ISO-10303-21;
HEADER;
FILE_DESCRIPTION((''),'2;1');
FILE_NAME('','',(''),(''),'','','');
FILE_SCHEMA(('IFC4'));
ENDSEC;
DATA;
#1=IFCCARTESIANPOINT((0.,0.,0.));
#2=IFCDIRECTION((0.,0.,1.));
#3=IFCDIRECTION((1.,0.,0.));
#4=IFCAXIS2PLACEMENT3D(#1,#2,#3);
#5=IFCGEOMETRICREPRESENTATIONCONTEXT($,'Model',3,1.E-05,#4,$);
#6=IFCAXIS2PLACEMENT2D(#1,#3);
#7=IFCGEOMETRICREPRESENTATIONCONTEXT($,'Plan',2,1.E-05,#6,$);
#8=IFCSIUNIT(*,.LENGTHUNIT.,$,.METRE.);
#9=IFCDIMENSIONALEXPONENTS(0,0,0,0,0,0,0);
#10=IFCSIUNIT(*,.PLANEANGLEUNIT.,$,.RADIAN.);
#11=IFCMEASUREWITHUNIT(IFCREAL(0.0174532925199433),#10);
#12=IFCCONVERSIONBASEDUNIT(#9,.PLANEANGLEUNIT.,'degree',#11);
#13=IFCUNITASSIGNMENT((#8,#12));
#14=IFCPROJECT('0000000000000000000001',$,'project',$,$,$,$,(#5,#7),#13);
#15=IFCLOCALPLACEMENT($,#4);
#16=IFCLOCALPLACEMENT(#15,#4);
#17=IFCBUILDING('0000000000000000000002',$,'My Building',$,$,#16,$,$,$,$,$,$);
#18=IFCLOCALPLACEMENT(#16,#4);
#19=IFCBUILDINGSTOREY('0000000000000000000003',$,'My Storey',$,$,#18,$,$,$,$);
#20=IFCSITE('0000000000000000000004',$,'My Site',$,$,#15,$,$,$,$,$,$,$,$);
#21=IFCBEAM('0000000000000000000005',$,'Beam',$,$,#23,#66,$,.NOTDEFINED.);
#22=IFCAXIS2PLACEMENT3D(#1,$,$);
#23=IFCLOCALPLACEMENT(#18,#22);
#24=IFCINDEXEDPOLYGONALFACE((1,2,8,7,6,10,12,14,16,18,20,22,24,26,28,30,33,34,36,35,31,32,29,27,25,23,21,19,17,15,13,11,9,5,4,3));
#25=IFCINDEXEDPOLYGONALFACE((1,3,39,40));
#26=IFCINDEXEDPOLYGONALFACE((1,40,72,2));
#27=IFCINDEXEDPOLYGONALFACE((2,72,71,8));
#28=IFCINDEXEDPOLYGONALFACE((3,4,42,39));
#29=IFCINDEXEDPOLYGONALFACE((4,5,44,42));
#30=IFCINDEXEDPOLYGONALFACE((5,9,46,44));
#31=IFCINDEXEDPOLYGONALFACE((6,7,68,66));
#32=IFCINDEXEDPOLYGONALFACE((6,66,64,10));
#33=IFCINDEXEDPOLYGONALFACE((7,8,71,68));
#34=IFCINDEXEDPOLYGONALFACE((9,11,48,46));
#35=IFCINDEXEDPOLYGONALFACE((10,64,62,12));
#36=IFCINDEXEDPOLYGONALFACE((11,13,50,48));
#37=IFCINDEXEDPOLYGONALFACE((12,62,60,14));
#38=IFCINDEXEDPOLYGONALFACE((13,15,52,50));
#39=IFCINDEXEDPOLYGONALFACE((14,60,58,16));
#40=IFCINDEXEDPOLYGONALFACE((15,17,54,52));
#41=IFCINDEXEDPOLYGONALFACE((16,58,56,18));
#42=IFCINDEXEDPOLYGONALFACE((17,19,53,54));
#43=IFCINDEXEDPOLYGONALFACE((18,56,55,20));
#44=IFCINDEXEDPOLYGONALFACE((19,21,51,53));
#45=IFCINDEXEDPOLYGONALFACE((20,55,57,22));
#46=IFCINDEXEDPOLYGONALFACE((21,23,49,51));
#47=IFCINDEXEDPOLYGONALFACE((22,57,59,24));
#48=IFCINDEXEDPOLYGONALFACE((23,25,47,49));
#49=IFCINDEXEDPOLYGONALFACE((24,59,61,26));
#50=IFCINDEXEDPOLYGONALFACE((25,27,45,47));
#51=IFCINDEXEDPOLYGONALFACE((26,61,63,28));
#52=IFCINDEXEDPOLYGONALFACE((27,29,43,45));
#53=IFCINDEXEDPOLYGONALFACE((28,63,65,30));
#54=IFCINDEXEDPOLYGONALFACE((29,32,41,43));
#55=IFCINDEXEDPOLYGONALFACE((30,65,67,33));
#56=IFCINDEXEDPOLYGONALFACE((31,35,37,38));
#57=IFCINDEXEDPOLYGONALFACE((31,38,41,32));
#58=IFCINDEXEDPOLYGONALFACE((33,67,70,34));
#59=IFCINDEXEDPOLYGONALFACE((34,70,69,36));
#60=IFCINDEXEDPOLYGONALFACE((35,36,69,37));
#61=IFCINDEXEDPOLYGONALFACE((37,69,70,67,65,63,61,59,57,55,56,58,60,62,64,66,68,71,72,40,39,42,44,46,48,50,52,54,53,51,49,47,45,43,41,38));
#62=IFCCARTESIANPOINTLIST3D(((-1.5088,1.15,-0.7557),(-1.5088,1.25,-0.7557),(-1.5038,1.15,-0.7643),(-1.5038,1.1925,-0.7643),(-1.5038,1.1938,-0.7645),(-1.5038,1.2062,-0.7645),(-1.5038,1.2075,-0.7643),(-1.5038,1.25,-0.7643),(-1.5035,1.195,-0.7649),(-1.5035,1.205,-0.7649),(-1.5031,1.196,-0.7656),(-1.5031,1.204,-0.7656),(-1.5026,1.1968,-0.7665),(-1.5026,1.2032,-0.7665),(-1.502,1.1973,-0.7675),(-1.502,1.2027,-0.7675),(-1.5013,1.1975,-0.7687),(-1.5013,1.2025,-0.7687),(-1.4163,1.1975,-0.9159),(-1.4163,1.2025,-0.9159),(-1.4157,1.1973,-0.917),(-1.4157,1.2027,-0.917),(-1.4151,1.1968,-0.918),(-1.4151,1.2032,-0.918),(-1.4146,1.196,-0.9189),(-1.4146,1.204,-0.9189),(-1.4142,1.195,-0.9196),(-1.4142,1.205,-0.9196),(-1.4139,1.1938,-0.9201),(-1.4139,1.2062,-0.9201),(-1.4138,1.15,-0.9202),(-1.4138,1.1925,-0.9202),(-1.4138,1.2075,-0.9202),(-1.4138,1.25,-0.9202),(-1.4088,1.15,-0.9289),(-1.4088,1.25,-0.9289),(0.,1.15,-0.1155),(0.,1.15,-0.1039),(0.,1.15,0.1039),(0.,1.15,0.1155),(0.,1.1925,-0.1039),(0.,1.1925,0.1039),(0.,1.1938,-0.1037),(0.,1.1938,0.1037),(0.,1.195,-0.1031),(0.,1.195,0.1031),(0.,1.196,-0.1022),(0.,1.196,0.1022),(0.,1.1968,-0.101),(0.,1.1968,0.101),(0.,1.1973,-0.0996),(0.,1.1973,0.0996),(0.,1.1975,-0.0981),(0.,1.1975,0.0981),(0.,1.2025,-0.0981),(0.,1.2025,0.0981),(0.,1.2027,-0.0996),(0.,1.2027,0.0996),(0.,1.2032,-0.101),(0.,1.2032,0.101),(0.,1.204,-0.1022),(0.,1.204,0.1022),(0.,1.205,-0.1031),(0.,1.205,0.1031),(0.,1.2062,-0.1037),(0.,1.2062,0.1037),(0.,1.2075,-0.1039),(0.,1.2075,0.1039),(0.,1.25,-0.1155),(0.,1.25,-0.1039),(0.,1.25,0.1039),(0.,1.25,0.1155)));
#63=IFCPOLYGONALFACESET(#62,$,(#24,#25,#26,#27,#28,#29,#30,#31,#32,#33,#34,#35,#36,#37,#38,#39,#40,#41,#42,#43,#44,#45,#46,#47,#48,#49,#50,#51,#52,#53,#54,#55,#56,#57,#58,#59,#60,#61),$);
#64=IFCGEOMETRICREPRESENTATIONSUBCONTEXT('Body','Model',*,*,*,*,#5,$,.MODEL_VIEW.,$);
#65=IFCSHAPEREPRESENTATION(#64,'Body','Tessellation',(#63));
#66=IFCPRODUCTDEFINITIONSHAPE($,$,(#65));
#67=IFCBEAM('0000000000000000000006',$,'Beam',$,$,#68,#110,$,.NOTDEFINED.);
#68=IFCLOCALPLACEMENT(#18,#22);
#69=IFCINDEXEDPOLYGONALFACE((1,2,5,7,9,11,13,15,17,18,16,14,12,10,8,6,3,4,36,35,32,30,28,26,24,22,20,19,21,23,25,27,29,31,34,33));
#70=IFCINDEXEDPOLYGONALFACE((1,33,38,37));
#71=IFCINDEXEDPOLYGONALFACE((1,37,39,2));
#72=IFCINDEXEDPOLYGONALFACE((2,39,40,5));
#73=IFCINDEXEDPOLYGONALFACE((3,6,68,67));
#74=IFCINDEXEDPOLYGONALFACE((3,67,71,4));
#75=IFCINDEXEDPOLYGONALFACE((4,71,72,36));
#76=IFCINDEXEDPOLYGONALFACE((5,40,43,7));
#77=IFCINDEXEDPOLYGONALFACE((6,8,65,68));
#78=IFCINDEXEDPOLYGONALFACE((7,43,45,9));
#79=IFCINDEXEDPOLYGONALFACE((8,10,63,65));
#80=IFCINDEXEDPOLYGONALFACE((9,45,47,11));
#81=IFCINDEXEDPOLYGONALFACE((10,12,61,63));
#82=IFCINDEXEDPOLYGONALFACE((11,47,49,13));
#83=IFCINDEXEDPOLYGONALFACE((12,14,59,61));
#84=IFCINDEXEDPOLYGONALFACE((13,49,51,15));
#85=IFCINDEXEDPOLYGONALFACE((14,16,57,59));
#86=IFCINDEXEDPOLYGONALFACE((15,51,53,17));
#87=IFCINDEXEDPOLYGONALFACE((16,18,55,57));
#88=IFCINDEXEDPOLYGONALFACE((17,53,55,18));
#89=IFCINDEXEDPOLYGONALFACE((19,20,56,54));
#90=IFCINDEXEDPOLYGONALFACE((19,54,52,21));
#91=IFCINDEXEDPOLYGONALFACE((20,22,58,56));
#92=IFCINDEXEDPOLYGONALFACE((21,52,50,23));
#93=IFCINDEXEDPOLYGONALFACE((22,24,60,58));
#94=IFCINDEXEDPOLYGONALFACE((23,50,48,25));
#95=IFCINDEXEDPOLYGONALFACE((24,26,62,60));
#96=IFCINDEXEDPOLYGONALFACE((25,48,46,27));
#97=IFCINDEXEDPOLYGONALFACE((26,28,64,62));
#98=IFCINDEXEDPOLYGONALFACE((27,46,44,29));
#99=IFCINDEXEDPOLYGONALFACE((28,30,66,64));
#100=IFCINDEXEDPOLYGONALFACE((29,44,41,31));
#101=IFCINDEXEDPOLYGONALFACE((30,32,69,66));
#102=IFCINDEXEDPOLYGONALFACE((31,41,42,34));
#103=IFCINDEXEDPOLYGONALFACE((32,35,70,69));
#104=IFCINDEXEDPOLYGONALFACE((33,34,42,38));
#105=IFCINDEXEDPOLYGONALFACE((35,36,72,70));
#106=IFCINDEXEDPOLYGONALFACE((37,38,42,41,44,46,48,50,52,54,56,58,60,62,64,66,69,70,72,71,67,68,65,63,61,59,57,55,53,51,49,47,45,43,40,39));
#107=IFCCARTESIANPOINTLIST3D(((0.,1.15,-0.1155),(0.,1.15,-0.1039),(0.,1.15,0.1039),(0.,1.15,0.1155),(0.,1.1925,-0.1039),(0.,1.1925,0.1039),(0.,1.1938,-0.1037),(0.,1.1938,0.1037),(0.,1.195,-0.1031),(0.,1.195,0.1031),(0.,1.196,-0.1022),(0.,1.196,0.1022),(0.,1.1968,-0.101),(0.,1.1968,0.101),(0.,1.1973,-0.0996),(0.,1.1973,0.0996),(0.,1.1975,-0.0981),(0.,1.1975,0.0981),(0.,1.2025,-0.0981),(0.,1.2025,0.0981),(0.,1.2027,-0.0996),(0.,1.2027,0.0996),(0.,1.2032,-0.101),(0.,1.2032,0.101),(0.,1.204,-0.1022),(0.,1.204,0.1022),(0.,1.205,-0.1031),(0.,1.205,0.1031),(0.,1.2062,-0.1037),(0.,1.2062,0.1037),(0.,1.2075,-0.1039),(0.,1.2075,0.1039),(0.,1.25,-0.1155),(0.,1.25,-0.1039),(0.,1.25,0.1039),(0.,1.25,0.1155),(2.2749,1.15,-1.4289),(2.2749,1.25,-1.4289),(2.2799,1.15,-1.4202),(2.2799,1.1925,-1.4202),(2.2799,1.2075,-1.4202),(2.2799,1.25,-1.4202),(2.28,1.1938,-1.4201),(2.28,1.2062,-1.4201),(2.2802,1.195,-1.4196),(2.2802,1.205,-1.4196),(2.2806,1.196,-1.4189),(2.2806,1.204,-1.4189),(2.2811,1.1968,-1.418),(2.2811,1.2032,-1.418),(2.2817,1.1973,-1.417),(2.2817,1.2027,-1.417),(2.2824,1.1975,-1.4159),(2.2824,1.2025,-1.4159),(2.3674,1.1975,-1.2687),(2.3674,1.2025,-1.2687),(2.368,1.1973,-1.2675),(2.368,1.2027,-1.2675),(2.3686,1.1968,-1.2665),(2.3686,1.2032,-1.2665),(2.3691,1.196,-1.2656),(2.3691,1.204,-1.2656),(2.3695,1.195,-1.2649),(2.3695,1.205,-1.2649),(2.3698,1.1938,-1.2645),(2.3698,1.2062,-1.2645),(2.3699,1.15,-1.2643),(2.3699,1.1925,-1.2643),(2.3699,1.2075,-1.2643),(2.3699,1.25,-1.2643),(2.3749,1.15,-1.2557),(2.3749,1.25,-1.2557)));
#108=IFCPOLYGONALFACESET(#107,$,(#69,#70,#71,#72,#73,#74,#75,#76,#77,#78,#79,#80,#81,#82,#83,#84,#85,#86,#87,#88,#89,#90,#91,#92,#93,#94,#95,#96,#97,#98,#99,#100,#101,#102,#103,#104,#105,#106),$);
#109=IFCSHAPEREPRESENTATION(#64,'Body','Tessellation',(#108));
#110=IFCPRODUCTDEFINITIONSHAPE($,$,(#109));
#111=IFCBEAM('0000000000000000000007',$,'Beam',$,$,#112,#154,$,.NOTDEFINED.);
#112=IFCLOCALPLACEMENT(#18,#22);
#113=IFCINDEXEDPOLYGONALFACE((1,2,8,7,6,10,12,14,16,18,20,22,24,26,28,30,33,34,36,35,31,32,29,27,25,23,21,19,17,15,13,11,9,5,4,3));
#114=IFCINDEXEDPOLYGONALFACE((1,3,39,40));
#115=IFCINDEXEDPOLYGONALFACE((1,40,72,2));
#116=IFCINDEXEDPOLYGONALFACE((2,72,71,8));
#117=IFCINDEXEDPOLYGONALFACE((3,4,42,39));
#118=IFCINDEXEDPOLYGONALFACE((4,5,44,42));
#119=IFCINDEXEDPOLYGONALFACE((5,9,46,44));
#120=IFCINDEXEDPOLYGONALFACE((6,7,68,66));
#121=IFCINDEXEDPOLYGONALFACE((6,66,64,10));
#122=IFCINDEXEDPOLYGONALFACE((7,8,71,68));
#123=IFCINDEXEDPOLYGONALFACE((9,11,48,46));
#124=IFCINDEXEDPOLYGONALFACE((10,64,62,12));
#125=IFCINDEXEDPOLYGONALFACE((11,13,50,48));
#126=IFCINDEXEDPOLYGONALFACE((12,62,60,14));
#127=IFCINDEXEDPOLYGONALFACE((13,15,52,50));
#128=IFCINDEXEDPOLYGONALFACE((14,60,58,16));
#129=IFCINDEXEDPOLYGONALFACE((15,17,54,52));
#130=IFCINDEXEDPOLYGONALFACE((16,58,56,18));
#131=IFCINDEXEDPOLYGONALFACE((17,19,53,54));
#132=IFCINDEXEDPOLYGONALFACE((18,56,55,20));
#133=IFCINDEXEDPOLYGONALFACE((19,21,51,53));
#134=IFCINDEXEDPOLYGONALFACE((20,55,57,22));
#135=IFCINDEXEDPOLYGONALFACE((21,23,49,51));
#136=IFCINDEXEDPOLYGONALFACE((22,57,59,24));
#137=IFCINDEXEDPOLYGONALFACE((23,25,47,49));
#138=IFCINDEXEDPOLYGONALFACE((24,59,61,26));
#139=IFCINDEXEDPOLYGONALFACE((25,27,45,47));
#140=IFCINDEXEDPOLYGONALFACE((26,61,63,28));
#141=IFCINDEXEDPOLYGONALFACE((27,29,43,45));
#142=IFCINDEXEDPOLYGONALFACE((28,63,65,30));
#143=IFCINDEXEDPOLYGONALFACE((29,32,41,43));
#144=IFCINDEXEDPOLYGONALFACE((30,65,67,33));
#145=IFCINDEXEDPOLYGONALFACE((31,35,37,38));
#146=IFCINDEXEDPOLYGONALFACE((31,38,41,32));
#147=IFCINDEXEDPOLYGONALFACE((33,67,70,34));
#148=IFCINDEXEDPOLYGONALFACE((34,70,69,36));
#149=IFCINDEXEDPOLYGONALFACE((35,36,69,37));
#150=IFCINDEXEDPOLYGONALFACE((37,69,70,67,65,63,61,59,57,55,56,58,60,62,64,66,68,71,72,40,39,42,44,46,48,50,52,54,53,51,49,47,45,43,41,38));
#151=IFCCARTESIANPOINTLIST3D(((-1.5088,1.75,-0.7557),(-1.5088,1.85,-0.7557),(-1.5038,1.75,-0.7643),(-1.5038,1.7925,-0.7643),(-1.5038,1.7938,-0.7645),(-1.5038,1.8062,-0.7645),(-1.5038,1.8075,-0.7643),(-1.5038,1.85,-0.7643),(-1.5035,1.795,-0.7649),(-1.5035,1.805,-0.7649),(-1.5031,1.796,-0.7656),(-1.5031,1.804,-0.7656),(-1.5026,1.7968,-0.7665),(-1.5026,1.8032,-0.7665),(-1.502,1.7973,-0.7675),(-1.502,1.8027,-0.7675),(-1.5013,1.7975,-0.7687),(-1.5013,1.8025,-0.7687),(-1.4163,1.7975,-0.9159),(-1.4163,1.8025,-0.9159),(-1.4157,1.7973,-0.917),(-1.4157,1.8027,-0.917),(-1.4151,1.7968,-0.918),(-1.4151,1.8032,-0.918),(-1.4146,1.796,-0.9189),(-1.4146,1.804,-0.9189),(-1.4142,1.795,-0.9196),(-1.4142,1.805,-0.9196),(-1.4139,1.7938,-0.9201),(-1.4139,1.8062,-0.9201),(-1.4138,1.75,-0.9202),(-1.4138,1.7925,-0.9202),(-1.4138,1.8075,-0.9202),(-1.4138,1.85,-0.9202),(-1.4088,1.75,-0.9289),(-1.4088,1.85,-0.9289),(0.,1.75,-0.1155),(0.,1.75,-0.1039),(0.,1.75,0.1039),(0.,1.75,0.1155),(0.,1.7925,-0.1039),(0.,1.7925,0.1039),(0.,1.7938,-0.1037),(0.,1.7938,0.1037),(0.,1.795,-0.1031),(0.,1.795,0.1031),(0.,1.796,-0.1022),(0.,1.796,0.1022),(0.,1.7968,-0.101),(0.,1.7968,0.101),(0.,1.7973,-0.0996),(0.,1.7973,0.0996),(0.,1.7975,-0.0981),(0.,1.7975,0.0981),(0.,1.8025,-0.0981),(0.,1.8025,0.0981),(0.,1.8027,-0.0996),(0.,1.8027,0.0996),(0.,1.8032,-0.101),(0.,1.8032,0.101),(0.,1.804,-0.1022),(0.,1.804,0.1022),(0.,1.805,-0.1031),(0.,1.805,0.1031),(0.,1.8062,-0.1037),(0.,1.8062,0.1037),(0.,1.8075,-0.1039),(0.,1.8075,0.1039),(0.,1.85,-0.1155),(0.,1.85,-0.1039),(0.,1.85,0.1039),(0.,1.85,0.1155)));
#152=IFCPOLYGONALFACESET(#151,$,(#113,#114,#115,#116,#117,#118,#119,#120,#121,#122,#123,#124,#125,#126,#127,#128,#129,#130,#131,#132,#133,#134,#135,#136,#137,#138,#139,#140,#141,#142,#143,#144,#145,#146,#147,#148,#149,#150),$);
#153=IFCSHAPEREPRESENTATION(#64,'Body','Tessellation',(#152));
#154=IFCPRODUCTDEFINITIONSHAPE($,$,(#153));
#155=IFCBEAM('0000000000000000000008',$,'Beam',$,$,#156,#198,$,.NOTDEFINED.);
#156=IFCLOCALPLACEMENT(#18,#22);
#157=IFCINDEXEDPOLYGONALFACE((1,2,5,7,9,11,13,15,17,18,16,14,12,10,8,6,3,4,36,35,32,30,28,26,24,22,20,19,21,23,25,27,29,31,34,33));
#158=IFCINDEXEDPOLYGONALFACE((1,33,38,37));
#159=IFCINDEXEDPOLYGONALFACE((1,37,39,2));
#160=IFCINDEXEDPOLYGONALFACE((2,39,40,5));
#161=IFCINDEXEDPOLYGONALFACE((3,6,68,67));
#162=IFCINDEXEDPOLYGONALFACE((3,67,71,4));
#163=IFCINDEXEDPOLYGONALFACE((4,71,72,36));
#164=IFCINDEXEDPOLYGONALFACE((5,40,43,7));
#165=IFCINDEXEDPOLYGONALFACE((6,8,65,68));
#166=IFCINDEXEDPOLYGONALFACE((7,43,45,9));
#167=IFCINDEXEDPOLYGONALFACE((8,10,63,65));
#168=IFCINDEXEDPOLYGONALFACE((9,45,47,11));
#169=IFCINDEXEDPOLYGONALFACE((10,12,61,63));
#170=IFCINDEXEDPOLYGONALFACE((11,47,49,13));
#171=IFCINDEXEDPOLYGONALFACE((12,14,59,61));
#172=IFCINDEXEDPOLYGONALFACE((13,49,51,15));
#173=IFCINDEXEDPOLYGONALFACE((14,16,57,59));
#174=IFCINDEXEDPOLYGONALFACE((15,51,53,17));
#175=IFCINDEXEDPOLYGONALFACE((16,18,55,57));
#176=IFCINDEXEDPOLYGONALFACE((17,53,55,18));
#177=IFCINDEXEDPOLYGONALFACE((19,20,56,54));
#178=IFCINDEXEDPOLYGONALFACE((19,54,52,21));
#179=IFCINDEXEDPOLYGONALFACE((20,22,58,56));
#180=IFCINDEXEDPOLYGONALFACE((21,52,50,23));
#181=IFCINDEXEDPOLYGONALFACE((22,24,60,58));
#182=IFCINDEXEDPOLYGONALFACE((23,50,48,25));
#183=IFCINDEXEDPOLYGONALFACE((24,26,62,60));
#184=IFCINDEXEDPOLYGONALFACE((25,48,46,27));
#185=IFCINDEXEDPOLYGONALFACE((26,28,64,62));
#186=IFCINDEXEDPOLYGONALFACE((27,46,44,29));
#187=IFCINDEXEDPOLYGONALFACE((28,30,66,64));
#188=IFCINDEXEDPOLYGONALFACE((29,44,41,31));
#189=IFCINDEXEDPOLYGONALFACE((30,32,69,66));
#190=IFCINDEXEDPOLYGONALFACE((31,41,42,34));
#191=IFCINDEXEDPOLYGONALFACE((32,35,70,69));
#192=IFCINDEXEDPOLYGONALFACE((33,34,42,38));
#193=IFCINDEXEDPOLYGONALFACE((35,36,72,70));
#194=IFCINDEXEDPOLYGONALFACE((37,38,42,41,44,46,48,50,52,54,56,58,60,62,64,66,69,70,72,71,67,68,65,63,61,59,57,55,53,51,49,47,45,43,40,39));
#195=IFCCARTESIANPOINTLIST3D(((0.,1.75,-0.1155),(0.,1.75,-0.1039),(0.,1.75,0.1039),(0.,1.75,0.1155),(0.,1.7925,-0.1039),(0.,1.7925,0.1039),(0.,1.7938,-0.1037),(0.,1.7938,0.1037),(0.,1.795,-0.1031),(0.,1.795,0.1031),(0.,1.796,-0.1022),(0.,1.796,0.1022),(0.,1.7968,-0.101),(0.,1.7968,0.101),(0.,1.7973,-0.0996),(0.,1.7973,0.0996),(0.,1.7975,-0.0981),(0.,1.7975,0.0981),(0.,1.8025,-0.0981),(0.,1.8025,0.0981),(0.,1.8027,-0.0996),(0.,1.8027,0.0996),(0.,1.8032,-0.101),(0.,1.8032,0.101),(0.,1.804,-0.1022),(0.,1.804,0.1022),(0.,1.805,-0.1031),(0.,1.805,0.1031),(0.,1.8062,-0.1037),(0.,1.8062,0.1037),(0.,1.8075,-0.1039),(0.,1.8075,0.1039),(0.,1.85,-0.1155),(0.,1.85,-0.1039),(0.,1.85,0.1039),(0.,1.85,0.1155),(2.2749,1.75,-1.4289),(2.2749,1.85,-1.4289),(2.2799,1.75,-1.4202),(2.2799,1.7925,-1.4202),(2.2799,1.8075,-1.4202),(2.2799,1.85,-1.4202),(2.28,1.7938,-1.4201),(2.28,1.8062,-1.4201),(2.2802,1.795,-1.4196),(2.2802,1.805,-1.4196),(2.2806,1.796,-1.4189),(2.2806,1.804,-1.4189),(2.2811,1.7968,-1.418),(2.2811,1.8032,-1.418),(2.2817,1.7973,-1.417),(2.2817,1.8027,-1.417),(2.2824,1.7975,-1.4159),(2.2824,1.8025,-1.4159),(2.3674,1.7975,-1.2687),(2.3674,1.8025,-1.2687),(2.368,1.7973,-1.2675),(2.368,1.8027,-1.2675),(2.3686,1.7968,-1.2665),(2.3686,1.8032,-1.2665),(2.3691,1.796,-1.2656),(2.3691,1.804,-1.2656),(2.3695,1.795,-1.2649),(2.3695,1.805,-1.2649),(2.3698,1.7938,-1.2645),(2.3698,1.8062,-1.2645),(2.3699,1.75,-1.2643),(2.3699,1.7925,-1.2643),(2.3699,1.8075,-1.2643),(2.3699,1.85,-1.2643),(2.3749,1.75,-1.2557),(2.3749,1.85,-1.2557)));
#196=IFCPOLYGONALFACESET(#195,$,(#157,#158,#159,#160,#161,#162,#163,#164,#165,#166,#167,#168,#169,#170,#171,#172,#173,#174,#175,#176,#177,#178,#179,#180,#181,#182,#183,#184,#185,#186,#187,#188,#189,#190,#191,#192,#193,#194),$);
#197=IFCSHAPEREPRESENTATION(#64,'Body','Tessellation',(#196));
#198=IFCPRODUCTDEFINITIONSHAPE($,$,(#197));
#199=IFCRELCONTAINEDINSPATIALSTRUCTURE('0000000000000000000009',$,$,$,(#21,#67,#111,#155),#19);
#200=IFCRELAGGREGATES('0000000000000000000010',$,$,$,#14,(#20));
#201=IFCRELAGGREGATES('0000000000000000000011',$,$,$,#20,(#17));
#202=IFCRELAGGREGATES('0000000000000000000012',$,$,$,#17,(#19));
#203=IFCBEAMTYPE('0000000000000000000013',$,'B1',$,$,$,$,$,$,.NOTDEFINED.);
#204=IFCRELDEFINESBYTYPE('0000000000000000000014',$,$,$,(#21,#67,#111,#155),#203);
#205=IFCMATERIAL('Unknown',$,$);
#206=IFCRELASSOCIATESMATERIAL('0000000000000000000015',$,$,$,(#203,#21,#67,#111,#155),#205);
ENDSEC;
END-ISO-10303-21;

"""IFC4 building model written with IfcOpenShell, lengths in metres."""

from ifc_helpers import new_model, entity, si_unit, converted_unit, frame, frame_2d, origin_with_axes, place, context, subcontext, project, spatial, i_section, extrude, clip, halfspace, material, material_profile, profile_set, profile_usage, type_object, element, save


model = new_model("IFC4")

# Units and contexts
model_context = context("Model", 3, precision=1e-05, world=origin_with_axes())
plan_context = context("Plan", 2, precision=1e-05, world=frame_2d((0.0, 0.0, 0.0), x_axis=(1.0, 0.0, 0.0)))
body_context = subcontext(model_context, "Body", "Model", "MODEL_VIEW")
ifc_project = project(units=[si_unit("LENGTHUNIT", "METRE"), converted_unit("PLANEANGLEUNIT", "degree", entity("IfcReal", 0.0174532925199433), si_unit("PLANEANGLEUNIT", "RADIAN"), dimensions=[0, 0, 0, 0, 0, 0, 0])], contexts=[model_context, plan_context])

# Site, building, storey
site_placement = place(None, origin_with_axes())
site = spatial("IfcSite", under=ifc_project, at=site_placement, Name="My Site")
building_placement = place(site_placement, origin_with_axes())
building = spatial("IfcBuilding", under=site, at=building_placement, Name="My Building")
storey_placement = place(building_placement, origin_with_axes())
storey = spatial("IfcBuildingStorey", under=building, at=storey_placement, Name="My Storey")

# Beams
ifc_material = material(Name="Unknown")
ifc_material_profile = material_profile(ifc_material, i_section(OverallWidth=0.1, OverallDepth=0.2, WebThickness=0.005, FlangeThickness=0.01, FilletRadius=0.005))
ifc_profile_set = profile_set([ifc_material_profile])
beam_type = type_object("IfcBeamType", Name="B1", PredefinedType="NOTDEFINED", material=ifc_profile_set)
ifc_profile_usage_1 = profile_usage(ifc_profile_set, cardinal=5)
beam_1_placement = place(storey_placement, frame((0.2732, 1.2, 0.1577), z_axis=(-0.866025, 0.0, -0.5), x_axis=(0.0, -1.0, 0.0)))
element("IfcBeam", 1, at=beam_1_placement, inside=storey, type_object=beam_type, material=ifc_profile_usage_1, Name="Beam", PredefinedType="NOTDEFINED", context=body_context, shape_type="Clipping", body=[
    clip(extrude(i_section(OverallWidth=0.1, OverallDepth=0.2, WebThickness=0.005, FlangeThickness=0.01, FilletRadius=0.005), origin_with_axes(), (0.0, 0.0, 1.0), 2.0), halfspace(frame((1.2, 0.1, 0.2577), z_axis=(0.0, -0.5, -0.866025), x_axis=(0.0, -0.866025, 0.5)), False)),
])
ifc_profile_usage_2 = profile_usage(ifc_profile_set, cardinal=5)
beam_2_placement = place(storey_placement, frame((-0.2732, 1.2, 0.1577), z_axis=(0.866025, 0.0, -0.5), x_axis=(0.0, 1.0, 0.0)))
element("IfcBeam", 2, at=beam_2_placement, inside=storey, type_object=beam_type, material=ifc_profile_usage_2, Name="Beam", PredefinedType="NOTDEFINED", context=body_context, shape_type="Clipping", body=[
    clip(extrude(i_section(OverallWidth=0.1, OverallDepth=0.2, WebThickness=0.005, FlangeThickness=0.01, FilletRadius=0.005), origin_with_axes(), (0.0, 0.0, 1.0), 3.0), halfspace(frame((-1.2, 0.1, 0.2577), z_axis=(0.0, -0.5, -0.866025), x_axis=(0.0, -0.866025, 0.5)), False)),
])
ifc_profile_usage_3 = profile_usage(ifc_profile_set, cardinal=5)
beam_3_placement = place(storey_placement, frame((0.2732, 1.8, 0.1577), z_axis=(-0.866025, 0.0, -0.5), x_axis=(0.0, -1.0, 0.0)))
element("IfcBeam", 3, at=beam_3_placement, inside=storey, type_object=beam_type, material=ifc_profile_usage_3, Name="Beam", PredefinedType="NOTDEFINED", context=body_context, shape_type="Clipping", body=[
    clip(extrude(i_section(OverallWidth=0.1, OverallDepth=0.2, WebThickness=0.005, FlangeThickness=0.01, FilletRadius=0.005), origin_with_axes(), (0.0, 0.0, 1.0), 2.0), halfspace(frame((1.8, 0.1, 0.2577), z_axis=(0.0, -0.5, -0.866025), x_axis=(0.0, -0.866025, 0.5)), False)),
])
ifc_profile_usage_4 = profile_usage(ifc_profile_set, cardinal=5)
beam_4_placement = place(storey_placement, frame((-0.2732, 1.8, 0.1577), z_axis=(0.866025, 0.0, -0.5), x_axis=(0.0, 1.0, 0.0)))
element("IfcBeam", 4, at=beam_4_placement, inside=storey, type_object=beam_type, material=ifc_profile_usage_4, Name="Beam", PredefinedType="NOTDEFINED", context=body_context, shape_type="Clipping", body=[
    clip(extrude(i_section(OverallWidth=0.1, OverallDepth=0.2, WebThickness=0.005, FlangeThickness=0.01, FilletRadius=0.005), origin_with_axes(), (0.0, 0.0, 1.0), 3.0), halfspace(frame((-1.8, 0.1, 0.2577), z_axis=(0.0, -0.5, -0.866025), x_axis=(0.0, -0.866025, 0.5)), False)),
])

save(model, "model.ifc")
